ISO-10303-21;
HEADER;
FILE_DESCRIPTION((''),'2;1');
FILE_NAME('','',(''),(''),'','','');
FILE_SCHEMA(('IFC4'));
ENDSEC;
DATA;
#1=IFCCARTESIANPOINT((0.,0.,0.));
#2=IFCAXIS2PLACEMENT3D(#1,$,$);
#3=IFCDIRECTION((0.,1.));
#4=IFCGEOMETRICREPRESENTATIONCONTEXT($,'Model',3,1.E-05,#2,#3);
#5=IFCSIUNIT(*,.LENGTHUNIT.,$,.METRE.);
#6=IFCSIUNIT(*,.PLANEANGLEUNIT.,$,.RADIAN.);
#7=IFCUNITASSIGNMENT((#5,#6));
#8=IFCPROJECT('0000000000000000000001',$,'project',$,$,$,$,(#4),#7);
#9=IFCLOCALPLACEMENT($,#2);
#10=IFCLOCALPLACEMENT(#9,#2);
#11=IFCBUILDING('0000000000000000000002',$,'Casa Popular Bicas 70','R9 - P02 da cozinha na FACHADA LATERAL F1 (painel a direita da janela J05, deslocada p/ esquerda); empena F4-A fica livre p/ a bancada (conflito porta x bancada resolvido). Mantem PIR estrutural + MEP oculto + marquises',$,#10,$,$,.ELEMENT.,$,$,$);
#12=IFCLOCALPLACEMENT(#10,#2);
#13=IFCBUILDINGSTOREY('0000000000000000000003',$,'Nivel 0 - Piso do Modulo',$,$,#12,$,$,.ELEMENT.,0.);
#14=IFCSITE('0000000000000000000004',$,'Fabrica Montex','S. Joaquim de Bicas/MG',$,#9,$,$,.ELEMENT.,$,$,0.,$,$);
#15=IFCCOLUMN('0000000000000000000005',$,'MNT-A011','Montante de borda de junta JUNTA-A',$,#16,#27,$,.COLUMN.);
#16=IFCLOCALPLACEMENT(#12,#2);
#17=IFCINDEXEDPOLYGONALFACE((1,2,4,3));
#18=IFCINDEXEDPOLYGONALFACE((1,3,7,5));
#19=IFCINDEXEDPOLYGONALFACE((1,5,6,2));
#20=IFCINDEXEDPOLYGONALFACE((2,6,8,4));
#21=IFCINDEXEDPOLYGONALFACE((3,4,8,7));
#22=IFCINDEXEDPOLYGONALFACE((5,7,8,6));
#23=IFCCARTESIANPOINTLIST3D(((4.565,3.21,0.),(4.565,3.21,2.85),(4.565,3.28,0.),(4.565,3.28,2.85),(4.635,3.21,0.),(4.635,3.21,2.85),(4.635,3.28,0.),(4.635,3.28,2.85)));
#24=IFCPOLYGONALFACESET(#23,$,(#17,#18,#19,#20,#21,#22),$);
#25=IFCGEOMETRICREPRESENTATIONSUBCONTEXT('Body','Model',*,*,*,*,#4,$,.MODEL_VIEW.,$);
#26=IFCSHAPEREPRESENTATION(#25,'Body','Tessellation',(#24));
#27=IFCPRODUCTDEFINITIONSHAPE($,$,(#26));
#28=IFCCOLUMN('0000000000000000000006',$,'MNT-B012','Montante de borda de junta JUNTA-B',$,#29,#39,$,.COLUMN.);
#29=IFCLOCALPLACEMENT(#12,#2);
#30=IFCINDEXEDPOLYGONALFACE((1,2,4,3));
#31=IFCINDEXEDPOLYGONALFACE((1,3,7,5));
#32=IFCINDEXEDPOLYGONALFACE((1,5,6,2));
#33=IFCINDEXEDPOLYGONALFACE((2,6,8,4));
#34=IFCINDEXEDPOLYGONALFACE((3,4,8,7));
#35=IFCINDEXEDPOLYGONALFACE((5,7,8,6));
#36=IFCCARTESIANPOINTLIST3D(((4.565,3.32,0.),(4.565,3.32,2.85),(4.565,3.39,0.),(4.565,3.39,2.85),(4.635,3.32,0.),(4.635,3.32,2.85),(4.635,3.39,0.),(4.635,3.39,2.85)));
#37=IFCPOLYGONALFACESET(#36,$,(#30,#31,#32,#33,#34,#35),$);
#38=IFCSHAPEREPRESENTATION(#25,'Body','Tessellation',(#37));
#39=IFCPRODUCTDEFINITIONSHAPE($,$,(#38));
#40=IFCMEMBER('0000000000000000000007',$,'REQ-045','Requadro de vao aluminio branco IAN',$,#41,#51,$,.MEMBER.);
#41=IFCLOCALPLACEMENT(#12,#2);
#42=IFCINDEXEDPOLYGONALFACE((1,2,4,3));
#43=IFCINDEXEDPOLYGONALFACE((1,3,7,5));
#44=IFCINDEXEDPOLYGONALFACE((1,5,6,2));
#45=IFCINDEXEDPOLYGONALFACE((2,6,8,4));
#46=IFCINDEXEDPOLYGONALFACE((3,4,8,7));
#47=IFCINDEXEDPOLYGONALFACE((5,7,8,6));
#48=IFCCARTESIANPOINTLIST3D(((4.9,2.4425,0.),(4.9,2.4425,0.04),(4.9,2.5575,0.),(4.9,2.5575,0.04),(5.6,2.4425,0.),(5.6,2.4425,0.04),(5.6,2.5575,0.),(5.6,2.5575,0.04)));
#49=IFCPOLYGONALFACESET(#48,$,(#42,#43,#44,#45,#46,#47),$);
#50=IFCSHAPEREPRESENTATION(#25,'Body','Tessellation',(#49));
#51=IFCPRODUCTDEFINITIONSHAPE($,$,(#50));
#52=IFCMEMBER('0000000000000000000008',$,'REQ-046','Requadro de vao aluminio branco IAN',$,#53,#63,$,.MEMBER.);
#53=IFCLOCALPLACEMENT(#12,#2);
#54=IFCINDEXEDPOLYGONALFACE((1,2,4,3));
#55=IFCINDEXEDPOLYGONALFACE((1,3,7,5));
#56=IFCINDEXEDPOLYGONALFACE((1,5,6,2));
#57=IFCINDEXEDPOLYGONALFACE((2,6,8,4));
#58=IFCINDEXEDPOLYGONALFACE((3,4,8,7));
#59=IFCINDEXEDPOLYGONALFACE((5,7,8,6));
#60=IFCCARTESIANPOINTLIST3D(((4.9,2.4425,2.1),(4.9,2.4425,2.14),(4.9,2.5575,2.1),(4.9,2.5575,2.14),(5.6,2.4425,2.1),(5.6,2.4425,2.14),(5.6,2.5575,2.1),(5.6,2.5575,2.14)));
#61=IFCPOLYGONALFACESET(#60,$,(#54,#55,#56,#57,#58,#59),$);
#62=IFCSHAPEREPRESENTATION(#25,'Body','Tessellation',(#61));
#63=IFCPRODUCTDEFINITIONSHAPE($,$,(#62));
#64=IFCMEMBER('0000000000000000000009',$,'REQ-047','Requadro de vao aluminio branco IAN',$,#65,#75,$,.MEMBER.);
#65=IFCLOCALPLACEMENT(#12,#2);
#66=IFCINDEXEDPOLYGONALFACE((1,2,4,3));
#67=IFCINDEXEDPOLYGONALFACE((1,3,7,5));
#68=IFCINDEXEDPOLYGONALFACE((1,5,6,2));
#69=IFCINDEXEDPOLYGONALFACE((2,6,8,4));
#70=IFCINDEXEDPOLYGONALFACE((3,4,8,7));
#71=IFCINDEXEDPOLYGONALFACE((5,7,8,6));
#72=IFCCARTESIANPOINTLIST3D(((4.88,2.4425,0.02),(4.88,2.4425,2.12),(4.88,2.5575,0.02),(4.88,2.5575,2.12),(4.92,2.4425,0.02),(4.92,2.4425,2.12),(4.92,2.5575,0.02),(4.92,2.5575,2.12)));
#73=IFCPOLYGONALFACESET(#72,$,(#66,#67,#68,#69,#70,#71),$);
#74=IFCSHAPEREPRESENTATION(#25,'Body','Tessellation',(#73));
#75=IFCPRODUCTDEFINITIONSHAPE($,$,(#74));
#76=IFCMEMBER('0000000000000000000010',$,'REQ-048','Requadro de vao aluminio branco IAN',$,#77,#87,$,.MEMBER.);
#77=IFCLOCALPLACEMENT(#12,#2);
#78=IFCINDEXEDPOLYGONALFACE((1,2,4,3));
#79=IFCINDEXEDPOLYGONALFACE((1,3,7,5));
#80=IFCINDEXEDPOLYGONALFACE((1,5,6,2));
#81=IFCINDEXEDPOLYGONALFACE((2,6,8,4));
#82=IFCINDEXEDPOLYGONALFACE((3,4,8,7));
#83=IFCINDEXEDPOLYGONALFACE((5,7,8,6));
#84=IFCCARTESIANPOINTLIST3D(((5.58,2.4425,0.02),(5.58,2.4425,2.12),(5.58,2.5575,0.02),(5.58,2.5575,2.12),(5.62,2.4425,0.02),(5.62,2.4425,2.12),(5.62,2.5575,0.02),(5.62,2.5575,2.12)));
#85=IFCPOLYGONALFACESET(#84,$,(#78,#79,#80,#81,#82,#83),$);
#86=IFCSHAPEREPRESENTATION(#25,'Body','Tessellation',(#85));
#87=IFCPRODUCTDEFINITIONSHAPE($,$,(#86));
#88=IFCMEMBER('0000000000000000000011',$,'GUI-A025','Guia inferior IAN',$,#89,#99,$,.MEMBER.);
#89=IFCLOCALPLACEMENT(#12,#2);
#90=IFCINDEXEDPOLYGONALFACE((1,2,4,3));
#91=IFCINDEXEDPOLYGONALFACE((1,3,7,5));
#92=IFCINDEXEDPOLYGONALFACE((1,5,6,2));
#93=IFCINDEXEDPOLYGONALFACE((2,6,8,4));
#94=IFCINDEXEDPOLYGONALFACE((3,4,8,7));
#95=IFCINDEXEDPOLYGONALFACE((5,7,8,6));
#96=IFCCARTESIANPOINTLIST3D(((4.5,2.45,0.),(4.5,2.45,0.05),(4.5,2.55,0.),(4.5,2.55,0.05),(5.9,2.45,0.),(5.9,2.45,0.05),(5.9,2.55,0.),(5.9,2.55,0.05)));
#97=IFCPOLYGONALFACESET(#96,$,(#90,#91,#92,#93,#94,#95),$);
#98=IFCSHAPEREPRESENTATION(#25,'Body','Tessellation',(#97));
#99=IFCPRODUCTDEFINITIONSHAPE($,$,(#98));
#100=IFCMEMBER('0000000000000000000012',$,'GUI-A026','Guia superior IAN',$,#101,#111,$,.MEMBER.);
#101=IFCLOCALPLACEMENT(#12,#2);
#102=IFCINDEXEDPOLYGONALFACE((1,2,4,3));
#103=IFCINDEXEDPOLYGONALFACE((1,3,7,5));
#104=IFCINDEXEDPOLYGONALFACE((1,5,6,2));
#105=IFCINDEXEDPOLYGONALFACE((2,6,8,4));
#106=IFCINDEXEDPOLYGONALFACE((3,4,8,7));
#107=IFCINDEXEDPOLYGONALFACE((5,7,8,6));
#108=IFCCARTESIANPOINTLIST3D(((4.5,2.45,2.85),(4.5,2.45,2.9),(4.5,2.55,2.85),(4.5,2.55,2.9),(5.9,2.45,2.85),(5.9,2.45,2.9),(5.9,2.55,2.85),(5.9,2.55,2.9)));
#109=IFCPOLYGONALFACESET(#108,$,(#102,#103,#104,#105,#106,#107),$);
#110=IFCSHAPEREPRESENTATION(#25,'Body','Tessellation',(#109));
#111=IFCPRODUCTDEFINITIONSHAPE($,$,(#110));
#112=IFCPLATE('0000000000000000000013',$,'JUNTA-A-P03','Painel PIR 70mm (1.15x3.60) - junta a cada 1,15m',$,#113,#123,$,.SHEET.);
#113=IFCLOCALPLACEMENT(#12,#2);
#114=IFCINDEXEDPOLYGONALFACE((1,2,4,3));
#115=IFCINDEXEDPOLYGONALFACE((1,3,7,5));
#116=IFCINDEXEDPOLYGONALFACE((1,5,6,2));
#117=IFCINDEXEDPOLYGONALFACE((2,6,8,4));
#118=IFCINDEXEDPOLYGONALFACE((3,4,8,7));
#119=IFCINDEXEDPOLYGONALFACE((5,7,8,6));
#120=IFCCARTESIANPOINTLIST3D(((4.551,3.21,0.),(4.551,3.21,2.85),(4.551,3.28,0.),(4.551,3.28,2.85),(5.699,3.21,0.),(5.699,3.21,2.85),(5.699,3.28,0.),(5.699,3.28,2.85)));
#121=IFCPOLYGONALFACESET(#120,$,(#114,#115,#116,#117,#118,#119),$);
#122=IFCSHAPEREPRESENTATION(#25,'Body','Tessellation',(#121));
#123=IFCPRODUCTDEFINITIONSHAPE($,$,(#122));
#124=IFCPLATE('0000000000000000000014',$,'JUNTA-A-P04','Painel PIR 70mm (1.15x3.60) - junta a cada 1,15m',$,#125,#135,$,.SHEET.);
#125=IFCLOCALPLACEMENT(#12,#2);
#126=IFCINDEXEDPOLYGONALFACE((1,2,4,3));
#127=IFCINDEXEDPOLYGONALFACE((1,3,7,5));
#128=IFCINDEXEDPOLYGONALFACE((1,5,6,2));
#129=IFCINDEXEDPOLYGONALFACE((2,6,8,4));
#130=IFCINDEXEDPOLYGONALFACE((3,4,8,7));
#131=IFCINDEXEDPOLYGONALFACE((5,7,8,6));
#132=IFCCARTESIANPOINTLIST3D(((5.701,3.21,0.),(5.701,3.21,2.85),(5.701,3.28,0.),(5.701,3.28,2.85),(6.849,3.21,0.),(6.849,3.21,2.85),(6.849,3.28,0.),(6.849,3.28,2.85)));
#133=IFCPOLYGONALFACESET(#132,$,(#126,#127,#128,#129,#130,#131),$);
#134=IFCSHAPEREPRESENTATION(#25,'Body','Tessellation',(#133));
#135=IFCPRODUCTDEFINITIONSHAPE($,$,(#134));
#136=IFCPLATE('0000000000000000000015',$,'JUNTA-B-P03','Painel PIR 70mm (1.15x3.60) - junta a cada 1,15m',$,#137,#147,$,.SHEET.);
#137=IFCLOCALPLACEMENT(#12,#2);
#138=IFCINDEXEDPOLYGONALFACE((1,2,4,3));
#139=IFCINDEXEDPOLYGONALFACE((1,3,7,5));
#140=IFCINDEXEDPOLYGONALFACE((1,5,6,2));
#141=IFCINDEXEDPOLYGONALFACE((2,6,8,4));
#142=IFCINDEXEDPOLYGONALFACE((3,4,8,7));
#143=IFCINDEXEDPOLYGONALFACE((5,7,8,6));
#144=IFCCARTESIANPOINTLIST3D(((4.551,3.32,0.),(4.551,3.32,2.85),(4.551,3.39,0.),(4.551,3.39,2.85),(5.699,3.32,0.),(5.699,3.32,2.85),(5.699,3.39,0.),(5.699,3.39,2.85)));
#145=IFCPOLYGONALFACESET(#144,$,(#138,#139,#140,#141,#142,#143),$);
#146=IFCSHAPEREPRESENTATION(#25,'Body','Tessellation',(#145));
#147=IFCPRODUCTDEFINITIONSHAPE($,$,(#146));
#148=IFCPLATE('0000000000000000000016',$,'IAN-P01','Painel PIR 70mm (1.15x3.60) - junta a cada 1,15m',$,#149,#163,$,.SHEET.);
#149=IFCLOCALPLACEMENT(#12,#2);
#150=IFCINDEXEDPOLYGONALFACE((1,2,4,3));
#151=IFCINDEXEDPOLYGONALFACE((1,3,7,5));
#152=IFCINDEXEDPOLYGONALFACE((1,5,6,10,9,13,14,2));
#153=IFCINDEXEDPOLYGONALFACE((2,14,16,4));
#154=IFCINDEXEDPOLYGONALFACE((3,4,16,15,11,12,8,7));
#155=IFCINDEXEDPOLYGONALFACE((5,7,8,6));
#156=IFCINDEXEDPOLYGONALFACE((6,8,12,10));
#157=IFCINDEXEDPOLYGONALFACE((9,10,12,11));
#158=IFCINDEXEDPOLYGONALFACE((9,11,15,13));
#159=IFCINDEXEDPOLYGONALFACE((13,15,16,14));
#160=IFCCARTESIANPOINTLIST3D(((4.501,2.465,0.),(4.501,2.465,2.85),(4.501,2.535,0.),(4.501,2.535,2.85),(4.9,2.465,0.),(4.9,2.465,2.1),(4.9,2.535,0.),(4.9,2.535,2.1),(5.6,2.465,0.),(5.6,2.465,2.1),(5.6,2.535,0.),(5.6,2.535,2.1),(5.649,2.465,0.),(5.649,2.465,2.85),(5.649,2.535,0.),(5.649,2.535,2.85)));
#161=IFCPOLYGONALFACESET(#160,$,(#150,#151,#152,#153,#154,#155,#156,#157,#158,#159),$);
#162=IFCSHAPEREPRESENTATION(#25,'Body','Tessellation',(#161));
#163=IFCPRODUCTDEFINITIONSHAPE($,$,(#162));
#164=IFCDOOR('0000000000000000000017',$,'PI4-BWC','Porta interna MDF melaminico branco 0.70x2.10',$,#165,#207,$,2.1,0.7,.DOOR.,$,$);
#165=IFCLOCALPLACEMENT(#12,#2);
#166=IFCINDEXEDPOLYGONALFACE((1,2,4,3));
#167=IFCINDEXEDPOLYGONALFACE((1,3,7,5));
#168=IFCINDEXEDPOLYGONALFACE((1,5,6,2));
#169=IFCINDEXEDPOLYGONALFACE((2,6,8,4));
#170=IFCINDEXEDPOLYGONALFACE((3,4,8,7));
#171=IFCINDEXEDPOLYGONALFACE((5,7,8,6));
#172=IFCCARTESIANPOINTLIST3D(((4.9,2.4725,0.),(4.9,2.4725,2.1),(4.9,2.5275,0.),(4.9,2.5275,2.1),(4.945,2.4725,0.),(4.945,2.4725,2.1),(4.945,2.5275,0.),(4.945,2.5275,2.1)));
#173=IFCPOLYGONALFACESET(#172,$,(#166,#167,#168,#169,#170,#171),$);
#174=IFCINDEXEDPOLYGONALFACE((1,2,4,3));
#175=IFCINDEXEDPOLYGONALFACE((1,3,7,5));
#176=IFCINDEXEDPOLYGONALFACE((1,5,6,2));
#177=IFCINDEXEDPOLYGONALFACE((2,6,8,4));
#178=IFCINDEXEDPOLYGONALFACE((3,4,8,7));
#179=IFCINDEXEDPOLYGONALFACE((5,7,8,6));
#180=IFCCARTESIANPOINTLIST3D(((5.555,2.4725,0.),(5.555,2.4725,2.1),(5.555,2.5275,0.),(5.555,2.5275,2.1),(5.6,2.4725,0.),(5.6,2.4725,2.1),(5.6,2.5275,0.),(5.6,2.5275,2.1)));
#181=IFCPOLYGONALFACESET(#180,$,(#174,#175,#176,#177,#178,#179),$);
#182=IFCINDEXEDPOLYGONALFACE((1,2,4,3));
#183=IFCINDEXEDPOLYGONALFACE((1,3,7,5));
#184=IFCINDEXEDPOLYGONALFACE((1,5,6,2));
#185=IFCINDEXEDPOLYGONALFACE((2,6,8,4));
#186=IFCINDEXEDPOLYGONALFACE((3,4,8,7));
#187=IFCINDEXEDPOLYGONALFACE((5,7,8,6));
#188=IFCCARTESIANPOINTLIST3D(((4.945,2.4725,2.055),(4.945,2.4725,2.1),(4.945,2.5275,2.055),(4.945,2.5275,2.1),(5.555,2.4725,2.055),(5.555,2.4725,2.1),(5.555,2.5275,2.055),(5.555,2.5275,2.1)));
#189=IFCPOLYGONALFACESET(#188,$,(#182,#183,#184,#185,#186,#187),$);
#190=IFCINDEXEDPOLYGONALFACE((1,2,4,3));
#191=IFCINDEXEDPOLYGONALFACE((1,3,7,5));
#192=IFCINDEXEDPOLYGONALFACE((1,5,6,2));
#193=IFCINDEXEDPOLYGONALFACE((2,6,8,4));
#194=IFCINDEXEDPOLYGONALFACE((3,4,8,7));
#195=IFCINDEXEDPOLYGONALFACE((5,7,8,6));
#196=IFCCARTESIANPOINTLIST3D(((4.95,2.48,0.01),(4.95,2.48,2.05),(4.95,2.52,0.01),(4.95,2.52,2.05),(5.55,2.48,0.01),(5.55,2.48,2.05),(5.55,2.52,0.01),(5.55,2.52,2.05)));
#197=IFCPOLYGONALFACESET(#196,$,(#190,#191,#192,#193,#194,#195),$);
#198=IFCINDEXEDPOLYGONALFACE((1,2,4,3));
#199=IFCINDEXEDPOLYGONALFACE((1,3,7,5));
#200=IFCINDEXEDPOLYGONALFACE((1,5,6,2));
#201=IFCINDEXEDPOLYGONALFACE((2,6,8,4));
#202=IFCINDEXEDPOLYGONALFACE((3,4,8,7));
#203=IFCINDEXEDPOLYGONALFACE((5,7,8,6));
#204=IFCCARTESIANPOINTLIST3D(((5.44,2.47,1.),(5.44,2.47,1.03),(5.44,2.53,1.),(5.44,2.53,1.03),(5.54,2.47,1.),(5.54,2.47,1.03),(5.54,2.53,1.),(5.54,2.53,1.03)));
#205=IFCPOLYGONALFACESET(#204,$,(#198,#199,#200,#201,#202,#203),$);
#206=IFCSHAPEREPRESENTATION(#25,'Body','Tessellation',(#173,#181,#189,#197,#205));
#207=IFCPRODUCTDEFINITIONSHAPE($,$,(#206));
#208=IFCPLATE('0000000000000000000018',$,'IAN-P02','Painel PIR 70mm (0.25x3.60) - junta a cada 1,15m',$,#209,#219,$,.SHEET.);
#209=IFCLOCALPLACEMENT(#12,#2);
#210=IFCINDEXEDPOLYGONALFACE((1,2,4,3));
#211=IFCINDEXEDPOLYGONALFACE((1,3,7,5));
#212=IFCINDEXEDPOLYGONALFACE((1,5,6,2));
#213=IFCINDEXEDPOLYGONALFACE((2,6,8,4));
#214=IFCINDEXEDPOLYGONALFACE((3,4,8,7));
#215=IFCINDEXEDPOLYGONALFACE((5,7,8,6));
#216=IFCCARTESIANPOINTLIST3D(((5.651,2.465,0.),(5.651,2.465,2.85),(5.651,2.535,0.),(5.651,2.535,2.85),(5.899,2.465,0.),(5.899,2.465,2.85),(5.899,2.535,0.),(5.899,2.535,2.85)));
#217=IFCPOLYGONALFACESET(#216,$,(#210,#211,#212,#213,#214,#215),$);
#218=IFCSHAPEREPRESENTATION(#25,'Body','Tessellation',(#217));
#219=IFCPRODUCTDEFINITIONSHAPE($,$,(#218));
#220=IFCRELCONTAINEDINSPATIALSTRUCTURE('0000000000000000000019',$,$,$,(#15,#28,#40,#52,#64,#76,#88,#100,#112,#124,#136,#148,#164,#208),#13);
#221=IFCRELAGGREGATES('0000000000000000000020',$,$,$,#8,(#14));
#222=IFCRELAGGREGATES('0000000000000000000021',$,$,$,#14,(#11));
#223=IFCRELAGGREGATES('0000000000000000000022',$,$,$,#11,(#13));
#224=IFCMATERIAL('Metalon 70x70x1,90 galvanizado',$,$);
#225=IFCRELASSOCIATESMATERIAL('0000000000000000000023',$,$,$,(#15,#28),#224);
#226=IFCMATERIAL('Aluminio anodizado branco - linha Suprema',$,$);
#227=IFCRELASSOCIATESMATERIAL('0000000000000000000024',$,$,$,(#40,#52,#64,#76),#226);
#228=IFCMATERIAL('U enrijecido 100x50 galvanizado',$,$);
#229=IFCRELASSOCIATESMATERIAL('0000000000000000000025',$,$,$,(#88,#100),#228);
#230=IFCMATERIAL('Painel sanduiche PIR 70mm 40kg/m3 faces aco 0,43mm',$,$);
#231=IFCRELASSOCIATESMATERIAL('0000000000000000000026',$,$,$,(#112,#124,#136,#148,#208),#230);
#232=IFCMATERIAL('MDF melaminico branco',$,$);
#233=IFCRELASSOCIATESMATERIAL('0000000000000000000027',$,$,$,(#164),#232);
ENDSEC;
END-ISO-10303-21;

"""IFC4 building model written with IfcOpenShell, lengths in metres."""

from ifc_helpers import new_model, si_unit, direction, frame, frame_2d, origin, origin_2d, place, context, subcontext, project, spatial, rectangle, extrude, material, element, fill, save


model = new_model("IFC4")

# Units and contexts
model_context = context("Model", 3, precision=1e-05, world=origin(), true_north=direction((0.0, 1.0)))
body_context = subcontext(model_context, "Body", "Model", "MODEL_VIEW")
ifc_project = project(units=[si_unit("LENGTHUNIT", "METRE"), si_unit("PLANEANGLEUNIT", "RADIAN")], contexts=[model_context])

# Site, building, storey
site_placement = place(None, origin())
site = spatial("IfcSite", under=ifc_project, at=site_placement, Name="Fabrica Montex", Description="S. Joaquim de Bicas/MG", CompositionType="ELEMENT", RefElevation=0.0)
building_placement = place(site_placement, origin())
building = spatial("IfcBuilding", under=site, at=building_placement, Name="Casa Popular Bicas 70", Description="R9 - P02 da cozinha na FACHADA LATERAL F1 (painel a direita da janela J05, deslocada p/ esquerda); empena F4-A fica livre p/ a bancada (conflito porta x bancada resolvido). Mantem PIR estrutural + MEP oculto + marquises", CompositionType="ELEMENT")
storey_placement = place(building_placement, origin())
storey = spatial("IfcBuildingStorey", under=building, at=storey_placement, Name="Nivel 0 - Piso do Modulo", CompositionType="ELEMENT", Elevation=0.0)

# Columns
ifc_material_1 = material(Name="Metalon 70x70x1,90 galvanizado")
for number, where, name, description in (
    (1, (4.6, 3.245, 0.0), "MNT-A011", "Montante de borda de junta JUNTA-A"),
    (2, (4.6, 3.355, 0.0), "MNT-B012", "Montante de borda de junta JUNTA-B"),
):
    element("IfcColumn", number, at=place(storey_placement, frame(where)), inside=storey, material=ifc_material_1, Name=name, Description=description, PredefinedType="COLUMN", context=body_context, shape_type="SweptSolid", body=[
        extrude(rectangle(XDim=0.07, YDim=0.07, at=origin_2d()), origin(), (0.0, 0.0, 1.0), 2.85),
    ])

# Members
ifc_material_2 = material(Name="Aluminio anodizado branco - linha Suprema")
for number, where, z_axis, x_axis, name in (
    (3, (4.9, 2.5, 0.02), (1.0, 0.0, 0.0), (0.0, 0.0, 1.0), "REQ-045"),
    (4, (4.9, 2.5, 2.12), (1.0, 0.0, 0.0), (0.0, 0.0, 1.0), "REQ-046"),
):
    element("IfcMember", number, at=place(storey_placement, frame(where, z_axis=z_axis, x_axis=x_axis)), inside=storey, material=ifc_material_2, Name=name, Description="Requadro de vao aluminio branco IAN", PredefinedType="MEMBER", context=body_context, shape_type="SweptSolid", body=[
        extrude(rectangle(XDim=0.04, YDim=0.115, at=origin_2d()), origin(), (0.0, 0.0, 1.0), 0.7),
    ])
for number, where, z_axis, x_axis, name in (
    (5, (4.9, 2.5, 0.02), (0.0, 0.0, 1.0), (1.0, 0.0, 0.0), "REQ-047"),
    (6, (5.6, 2.5, 0.02), (0.0, 0.0, 1.0), (1.0, 0.0, 0.0), "REQ-048"),
):
    element("IfcMember", number, at=place(storey_placement, frame(where, z_axis=z_axis, x_axis=x_axis)), inside=storey, material=ifc_material_2, Name=name, Description="Requadro de vao aluminio branco IAN", PredefinedType="MEMBER", context=body_context, shape_type="SweptSolid", body=[
        extrude(rectangle(XDim=0.04, YDim=0.115, at=origin_2d()), origin(), (0.0, 0.0, 1.0), 2.1),
    ])
ifc_material_3 = material(Name="U enrijecido 100x50 galvanizado")
for number, where, z_axis, x_axis, name, description in (
    (7, (4.5, 2.5, 0.025), (1.0, 0.0, 0.0), (0.0, 0.0, 1.0), "GUI-A025", "Guia inferior IAN"),
    (8, (4.5, 2.5, 2.875), (1.0, 0.0, 0.0), (0.0, 0.0, 1.0), "GUI-A026", "Guia superior IAN"),
):
    element("IfcMember", number, at=place(storey_placement, frame(where, z_axis=z_axis, x_axis=x_axis)), inside=storey, material=ifc_material_3, Name=name, Description=description, PredefinedType="MEMBER", context=body_context, shape_type="SweptSolid", body=[
        extrude(rectangle(XDim=0.05, YDim=0.1, at=origin_2d()), origin(), (0.0, 0.0, 1.0), 1.4),
    ])

# Plates
ifc_material_4 = material(Name="Painel sanduiche PIR 70mm 40kg/m3 faces aco 0,43mm")
for number, where, x_axis, name in (
    (9, (4.551, 3.245, 0.0), (1.0, 0.0, 0.0), "JUNTA-A-P03"),
    (10, (5.701, 3.245, 0.0), (1.0, 0.0, 0.0), "JUNTA-A-P04"),
    (11, (4.551, 3.355, 0.0), (1.0, 0.0, 0.0), "JUNTA-B-P03"),
):
    element("IfcPlate", number, at=place(storey_placement, frame(where, x_axis=x_axis)), inside=storey, material=ifc_material_4, Name=name, Description="Painel PIR 70mm (1.15x3.60) - junta a cada 1,15m", PredefinedType="SHEET", context=body_context, shape_type="SweptSolid", body=[
        extrude(rectangle(XDim=1.148, YDim=0.07, at=frame_2d((0.574, 0.0))), origin(), (0.0, 0.0, 1.0), 2.85),
    ])

# Plate, opening, door
plate_1_placement = place(storey_placement, frame((4.501, 2.5, 0.0), x_axis=(1.0, 0.0, 0.0)))
plate_1 = element("IfcPlate", 12, at=plate_1_placement, inside=storey, material=ifc_material_4, Name="IAN-P01", Description="Painel PIR 70mm (1.15x3.60) - junta a cada 1,15m", PredefinedType="SHEET", context=body_context, shape_type="SweptSolid", body=[
    extrude(rectangle(XDim=1.148, YDim=0.07, at=frame_2d((0.574, 0.0))), origin(), (0.0, 0.0, 1.0), 2.85),
])
opening_1_placement = place(storey_placement, frame((5.25, 2.5, 0.0)))
opening_1 = element("IfcOpeningElement", 13, at=opening_1_placement, cuts=plate_1, PredefinedType="OPENING", context=body_context, shape_type="SweptSolid", body=[
    extrude(rectangle(XDim=0.7, YDim=0.1, at=origin_2d()), origin(), (0.0, 0.0, 1.0), 2.1),
])
ifc_material_5 = material(Name="MDF melaminico branco")
door_placement = place(storey_placement, frame((4.9, 2.5, 0.0), x_axis=(1.0, 0.0, 0.0)))
door = element("IfcDoor", 14, at=door_placement, inside=storey, material=ifc_material_5, Name="PI4-BWC", Description="Porta interna MDF melaminico branco 0.70x2.10", OverallHeight=2.1, OverallWidth=0.7, PredefinedType="DOOR", context=body_context, shape_type="SweptSolid", body=[
    extrude(rectangle(XDim=0.045, YDim=0.055, at=frame_2d((0.0225, 0.0))), origin(), (0.0, 0.0, 1.0), 2.1),
    extrude(rectangle(XDim=0.045, YDim=0.055, at=frame_2d((0.6775, 0.0))), origin(), (0.0, 0.0, 1.0), 2.1),
    extrude(rectangle(XDim=0.61, YDim=0.055, at=frame_2d((0.35, 0.0))), frame((0.0, 0.0, 2.055)), (0.0, 0.0, 1.0), 0.045),
    extrude(rectangle(XDim=0.6, YDim=0.04, at=frame_2d((0.35, 0.0))), frame((0.0, 0.0, 0.01)), (0.0, 0.0, 1.0), 2.04),
    extrude(rectangle(XDim=0.1, YDim=0.06, at=frame_2d((0.59, 0.0))), frame((0.0, 0.0, 1.0)), (0.0, 0.0, 1.0), 0.03),
])
fill(opening_1, door)

# Plate
plate_2_placement = place(storey_placement, frame((5.651, 2.5, 0.0), x_axis=(1.0, 0.0, 0.0)))
element("IfcPlate", 15, at=plate_2_placement, inside=storey, material=ifc_material_4, Name="IAN-P02", Description="Painel PIR 70mm (0.25x3.60) - junta a cada 1,15m", PredefinedType="SHEET", context=body_context, shape_type="SweptSolid", body=[
    extrude(rectangle(XDim=0.248, YDim=0.07, at=frame_2d((0.124, 0.0))), origin(), (0.0, 0.0, 1.0), 2.85),
])

save(model, "model.ifc")
